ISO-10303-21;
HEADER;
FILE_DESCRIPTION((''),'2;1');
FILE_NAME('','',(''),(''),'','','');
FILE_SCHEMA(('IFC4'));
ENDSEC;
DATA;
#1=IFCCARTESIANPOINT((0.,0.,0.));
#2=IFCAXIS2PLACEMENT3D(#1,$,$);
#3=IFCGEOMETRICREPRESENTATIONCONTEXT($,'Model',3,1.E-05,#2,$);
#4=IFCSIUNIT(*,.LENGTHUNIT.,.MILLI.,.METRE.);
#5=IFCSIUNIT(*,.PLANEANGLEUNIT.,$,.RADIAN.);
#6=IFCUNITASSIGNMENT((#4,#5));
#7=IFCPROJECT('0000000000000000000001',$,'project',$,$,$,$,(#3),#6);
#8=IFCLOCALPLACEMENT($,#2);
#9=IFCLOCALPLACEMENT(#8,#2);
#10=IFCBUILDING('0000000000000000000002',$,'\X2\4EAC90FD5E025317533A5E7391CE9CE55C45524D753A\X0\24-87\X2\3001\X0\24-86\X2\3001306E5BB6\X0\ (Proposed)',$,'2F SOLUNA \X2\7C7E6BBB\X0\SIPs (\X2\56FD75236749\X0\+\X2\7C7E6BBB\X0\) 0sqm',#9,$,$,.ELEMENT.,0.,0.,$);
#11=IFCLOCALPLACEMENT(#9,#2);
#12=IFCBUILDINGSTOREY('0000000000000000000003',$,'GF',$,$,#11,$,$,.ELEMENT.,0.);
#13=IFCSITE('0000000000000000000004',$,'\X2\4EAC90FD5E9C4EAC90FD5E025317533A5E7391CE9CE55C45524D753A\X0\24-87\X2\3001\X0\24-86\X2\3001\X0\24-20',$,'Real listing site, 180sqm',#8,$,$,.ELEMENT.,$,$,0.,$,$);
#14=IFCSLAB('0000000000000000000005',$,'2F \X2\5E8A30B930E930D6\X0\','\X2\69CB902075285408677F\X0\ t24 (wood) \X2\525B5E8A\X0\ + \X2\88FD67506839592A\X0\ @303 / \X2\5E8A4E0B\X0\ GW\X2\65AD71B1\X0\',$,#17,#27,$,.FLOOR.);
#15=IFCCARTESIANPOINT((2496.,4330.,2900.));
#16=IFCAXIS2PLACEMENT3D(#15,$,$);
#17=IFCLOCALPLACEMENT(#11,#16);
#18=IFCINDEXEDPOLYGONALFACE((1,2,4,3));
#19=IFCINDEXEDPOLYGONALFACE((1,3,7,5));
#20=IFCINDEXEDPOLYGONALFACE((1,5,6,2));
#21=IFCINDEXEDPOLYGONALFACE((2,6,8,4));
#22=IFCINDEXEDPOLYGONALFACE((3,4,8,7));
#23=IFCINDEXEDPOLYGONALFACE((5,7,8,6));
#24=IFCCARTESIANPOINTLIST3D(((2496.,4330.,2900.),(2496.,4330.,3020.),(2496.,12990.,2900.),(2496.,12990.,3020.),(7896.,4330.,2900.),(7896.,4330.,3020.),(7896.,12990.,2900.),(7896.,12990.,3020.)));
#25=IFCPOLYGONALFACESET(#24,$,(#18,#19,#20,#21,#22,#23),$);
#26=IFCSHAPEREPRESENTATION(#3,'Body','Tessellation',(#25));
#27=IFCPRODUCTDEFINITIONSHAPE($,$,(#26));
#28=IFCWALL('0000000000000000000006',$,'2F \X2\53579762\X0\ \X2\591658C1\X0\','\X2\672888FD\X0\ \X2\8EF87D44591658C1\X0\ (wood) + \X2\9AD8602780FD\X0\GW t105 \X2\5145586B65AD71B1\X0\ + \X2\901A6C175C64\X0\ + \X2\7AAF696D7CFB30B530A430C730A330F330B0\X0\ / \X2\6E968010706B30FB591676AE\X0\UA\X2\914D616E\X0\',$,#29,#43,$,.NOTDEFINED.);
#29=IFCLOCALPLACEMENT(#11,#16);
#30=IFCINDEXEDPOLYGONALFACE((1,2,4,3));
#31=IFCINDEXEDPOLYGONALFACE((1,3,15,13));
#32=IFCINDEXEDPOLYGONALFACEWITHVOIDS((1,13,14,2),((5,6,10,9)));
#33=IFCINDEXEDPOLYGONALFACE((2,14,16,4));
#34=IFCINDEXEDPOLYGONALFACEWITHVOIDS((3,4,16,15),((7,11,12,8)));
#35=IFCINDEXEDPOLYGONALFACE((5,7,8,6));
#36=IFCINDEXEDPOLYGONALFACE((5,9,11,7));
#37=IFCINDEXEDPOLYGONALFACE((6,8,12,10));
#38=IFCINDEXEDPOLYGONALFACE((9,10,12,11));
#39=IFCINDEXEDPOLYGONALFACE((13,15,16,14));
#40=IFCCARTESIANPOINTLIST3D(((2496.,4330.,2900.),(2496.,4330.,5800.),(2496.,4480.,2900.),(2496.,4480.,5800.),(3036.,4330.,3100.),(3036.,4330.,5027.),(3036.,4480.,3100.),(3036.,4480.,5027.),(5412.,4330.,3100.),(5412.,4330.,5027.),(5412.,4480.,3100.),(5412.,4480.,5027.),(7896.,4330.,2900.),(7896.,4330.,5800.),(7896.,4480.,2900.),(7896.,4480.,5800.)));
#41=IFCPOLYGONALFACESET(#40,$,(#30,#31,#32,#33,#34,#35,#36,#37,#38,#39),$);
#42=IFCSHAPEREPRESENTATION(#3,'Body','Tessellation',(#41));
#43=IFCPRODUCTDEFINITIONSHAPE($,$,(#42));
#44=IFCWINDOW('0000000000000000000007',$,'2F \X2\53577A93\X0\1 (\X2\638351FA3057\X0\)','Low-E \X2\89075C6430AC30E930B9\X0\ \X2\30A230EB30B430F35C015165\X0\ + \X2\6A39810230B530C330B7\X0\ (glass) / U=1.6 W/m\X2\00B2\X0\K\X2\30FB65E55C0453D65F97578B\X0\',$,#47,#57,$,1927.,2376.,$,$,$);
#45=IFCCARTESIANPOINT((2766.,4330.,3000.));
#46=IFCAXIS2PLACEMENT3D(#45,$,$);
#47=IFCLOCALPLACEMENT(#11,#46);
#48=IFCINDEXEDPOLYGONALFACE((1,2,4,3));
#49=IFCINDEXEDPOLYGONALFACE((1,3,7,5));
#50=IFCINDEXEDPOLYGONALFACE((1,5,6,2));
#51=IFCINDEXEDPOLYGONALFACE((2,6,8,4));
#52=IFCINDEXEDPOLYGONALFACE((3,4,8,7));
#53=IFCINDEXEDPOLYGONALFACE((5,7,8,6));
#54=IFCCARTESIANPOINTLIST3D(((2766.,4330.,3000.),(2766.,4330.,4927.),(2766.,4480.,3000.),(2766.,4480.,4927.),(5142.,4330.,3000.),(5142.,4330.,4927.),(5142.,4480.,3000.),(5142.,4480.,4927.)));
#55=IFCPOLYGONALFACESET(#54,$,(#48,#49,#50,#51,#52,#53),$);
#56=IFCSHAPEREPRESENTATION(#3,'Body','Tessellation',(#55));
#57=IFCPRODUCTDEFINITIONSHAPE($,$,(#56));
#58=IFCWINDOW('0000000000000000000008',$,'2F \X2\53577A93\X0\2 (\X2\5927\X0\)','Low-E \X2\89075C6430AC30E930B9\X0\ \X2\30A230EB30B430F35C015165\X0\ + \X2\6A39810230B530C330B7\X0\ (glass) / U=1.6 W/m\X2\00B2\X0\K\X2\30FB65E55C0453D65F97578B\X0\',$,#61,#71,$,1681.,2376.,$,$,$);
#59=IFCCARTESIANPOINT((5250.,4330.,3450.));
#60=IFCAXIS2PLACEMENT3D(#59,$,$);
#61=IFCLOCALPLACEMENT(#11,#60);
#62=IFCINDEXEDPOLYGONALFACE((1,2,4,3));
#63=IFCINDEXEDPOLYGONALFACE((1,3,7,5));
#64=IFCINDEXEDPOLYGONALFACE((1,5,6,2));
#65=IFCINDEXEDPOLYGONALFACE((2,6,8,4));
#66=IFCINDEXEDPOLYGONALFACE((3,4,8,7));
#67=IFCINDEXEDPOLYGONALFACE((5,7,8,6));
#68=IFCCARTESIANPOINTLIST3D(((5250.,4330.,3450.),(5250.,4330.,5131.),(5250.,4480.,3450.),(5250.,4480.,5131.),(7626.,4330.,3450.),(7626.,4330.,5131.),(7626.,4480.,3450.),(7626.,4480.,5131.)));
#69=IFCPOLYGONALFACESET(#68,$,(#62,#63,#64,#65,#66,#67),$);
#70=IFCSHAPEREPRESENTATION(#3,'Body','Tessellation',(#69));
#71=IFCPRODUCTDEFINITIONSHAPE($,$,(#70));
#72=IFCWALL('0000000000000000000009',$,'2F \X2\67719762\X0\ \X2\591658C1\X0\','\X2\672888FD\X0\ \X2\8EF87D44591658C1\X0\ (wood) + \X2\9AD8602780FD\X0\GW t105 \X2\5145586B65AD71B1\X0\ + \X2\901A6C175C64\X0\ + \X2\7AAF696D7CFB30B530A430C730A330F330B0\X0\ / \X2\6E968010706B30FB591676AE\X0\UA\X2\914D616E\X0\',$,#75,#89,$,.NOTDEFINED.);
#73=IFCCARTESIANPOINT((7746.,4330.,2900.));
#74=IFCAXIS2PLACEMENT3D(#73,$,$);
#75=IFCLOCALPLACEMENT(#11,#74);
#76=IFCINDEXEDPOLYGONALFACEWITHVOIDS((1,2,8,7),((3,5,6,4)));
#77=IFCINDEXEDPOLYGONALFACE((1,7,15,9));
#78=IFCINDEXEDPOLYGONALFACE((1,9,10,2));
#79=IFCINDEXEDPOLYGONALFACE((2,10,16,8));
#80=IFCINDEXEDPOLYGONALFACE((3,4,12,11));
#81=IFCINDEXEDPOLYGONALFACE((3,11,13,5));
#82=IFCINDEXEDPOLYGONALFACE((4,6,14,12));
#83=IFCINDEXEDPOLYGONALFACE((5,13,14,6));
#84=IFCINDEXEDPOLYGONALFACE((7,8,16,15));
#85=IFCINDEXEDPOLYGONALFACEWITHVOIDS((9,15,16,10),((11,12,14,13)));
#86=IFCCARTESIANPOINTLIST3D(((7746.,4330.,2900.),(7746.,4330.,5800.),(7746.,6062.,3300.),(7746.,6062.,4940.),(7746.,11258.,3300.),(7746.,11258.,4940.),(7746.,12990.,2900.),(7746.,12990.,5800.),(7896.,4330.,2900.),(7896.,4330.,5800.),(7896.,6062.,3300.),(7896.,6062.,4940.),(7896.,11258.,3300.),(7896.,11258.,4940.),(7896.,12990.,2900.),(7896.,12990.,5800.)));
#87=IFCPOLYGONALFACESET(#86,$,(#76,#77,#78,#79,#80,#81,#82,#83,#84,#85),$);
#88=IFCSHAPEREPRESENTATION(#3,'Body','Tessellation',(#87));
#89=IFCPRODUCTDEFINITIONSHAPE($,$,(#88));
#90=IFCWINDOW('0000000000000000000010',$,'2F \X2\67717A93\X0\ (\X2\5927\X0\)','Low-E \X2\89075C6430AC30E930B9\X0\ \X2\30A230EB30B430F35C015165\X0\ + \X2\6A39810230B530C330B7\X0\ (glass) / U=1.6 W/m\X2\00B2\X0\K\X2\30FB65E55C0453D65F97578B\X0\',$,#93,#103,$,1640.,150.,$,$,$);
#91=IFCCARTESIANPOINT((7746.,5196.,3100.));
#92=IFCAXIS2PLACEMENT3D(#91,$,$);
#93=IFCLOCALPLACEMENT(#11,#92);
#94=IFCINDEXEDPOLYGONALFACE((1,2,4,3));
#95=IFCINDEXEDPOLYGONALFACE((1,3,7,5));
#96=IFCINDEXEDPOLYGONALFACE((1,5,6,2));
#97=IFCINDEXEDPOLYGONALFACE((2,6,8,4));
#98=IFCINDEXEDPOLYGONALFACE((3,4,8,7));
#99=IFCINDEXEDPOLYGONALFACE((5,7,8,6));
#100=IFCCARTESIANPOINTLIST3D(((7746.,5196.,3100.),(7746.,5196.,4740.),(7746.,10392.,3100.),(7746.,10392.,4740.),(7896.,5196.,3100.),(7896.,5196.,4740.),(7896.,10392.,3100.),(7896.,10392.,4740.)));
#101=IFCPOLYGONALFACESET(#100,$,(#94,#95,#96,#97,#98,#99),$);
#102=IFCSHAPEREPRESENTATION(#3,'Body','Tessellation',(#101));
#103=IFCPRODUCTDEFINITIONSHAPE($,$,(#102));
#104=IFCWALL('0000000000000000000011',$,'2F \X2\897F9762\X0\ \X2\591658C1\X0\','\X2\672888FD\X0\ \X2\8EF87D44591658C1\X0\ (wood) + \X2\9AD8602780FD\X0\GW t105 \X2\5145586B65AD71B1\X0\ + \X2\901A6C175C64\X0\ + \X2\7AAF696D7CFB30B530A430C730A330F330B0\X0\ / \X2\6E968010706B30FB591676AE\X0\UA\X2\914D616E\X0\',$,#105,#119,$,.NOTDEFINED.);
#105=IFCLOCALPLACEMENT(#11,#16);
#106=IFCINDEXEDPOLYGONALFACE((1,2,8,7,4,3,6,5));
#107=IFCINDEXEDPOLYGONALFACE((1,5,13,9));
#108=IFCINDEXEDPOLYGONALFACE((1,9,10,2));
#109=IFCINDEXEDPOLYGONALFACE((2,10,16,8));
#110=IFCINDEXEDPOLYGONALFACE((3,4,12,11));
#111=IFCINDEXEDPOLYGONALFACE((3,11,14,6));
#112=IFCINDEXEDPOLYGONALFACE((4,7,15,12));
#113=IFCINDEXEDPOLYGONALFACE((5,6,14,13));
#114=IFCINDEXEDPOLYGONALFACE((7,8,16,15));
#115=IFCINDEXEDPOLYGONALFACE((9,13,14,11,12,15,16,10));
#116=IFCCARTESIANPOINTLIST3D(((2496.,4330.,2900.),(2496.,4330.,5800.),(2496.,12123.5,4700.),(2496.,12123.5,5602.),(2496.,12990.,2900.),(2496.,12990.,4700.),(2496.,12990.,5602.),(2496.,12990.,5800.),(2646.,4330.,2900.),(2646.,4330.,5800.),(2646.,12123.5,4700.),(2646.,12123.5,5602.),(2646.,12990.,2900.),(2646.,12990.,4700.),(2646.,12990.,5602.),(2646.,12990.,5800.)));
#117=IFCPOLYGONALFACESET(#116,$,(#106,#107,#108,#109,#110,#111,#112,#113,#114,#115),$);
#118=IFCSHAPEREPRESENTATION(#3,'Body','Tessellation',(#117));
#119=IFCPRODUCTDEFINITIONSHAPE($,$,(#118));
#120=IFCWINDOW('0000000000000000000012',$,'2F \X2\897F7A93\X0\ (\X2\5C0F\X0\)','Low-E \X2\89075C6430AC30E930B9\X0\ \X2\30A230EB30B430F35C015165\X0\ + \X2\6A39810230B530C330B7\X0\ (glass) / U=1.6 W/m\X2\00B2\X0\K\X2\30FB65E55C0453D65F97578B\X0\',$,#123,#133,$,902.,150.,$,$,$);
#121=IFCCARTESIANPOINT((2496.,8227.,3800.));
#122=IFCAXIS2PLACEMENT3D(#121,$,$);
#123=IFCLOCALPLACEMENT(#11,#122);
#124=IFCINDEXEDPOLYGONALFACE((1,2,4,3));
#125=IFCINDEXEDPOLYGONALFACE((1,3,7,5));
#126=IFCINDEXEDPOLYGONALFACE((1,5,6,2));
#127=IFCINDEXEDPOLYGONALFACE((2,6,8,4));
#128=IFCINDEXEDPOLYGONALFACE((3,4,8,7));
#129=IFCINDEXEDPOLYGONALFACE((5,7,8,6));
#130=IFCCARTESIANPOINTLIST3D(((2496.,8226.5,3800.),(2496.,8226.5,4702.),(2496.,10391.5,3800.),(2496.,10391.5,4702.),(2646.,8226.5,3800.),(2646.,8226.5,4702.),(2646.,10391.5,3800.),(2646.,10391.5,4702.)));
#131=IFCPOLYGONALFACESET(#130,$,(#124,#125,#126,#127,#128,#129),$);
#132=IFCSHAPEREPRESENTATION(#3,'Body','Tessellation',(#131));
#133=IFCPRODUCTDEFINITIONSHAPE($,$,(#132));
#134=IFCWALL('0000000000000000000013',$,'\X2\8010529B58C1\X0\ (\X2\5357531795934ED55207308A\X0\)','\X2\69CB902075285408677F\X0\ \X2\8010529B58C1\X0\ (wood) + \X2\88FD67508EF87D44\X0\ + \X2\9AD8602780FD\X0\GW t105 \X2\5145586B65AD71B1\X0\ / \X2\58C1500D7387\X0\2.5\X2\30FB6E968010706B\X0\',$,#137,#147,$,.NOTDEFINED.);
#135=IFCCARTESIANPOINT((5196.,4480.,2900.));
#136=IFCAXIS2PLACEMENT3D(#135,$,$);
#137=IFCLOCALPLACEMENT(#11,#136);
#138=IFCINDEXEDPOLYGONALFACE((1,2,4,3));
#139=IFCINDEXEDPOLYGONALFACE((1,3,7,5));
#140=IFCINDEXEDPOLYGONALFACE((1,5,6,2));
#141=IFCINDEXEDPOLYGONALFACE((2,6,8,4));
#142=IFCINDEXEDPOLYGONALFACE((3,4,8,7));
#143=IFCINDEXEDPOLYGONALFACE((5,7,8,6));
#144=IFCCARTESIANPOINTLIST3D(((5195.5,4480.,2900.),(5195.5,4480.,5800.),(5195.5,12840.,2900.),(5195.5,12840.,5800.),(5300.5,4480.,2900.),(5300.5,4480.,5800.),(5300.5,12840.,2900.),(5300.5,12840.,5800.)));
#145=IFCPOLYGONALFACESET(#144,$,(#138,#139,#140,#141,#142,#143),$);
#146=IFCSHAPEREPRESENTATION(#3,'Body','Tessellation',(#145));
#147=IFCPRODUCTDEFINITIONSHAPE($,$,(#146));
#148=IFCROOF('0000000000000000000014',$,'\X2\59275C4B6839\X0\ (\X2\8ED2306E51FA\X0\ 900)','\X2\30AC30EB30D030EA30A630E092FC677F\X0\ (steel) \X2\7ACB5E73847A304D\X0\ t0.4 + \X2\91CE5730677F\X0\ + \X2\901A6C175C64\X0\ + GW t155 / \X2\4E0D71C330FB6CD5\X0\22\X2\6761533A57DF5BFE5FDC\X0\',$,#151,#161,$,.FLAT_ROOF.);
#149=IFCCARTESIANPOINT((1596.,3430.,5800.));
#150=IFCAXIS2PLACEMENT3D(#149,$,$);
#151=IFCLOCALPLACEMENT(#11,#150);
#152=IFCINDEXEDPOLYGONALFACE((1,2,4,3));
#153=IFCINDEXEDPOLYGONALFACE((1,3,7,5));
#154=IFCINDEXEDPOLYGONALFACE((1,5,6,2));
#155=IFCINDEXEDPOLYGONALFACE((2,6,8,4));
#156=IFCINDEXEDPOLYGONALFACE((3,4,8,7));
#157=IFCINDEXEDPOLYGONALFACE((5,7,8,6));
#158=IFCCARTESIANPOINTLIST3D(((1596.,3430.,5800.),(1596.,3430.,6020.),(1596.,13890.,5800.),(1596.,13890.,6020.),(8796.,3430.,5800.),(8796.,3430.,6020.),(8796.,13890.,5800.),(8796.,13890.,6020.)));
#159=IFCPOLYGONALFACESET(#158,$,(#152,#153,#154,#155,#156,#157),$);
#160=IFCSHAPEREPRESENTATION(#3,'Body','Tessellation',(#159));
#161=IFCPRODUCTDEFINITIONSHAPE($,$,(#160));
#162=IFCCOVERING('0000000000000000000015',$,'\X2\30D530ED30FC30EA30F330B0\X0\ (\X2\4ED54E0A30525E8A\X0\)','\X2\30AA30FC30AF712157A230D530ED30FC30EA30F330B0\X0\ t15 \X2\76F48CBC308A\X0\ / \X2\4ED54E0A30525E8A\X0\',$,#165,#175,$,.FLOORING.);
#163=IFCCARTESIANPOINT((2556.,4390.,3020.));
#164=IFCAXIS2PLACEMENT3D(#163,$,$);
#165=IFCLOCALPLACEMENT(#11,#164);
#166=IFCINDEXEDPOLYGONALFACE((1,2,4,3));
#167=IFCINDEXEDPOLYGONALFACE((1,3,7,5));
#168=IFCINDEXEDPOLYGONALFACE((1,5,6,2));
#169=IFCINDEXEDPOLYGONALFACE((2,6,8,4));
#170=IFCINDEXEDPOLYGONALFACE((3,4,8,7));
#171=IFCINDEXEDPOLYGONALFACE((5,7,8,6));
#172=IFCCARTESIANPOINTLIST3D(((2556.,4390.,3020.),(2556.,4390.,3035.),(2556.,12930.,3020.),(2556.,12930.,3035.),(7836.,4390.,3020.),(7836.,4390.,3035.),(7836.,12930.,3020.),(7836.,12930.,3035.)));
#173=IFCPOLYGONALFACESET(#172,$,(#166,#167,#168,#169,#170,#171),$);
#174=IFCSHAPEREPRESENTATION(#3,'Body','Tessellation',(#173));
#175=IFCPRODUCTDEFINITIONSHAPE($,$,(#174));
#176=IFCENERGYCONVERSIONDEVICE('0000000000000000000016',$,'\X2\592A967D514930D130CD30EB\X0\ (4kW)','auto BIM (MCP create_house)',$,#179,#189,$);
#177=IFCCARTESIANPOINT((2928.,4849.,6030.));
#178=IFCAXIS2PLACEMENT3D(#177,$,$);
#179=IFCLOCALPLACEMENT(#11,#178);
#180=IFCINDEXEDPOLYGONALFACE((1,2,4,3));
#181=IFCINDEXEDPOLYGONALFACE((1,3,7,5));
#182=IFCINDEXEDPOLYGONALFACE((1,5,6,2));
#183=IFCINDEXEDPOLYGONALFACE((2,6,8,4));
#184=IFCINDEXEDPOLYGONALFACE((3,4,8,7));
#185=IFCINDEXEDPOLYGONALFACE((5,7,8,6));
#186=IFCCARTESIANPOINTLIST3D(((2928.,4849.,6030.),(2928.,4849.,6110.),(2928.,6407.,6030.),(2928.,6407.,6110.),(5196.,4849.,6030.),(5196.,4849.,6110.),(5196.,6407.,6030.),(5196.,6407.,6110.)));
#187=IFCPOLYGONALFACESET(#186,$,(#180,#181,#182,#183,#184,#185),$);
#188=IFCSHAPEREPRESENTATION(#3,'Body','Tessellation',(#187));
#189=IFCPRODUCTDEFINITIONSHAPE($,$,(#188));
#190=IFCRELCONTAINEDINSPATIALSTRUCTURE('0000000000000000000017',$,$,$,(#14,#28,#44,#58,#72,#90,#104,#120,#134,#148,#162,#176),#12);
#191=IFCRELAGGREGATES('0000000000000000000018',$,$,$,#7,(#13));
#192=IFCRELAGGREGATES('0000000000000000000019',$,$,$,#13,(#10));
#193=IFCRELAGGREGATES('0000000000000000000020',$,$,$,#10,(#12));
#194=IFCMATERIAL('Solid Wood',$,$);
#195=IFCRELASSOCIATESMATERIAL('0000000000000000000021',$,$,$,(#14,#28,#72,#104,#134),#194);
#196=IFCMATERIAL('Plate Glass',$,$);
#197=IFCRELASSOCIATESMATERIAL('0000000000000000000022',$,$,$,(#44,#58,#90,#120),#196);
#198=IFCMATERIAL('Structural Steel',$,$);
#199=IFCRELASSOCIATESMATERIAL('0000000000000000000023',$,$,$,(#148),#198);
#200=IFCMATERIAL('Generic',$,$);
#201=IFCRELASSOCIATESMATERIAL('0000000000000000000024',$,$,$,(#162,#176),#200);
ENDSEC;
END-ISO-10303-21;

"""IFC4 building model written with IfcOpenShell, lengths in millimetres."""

from ifc_helpers import new_model, si_unit, frame, frame_2d, origin, place, context, project, spatial, rectangle, extrude, material, element, fill, save


model = new_model("IFC4")

# Units and contexts
model_context = context("Model", 3, precision=1e-05, world=origin())
ifc_project = project(units=[si_unit("LENGTHUNIT", "METRE", prefix="MILLI"), si_unit("PLANEANGLEUNIT", "RADIAN")], contexts=[model_context])

# Site, building, storey
site_placement = place(None, origin())
site = spatial("IfcSite", under=ifc_project, at=site_placement, Name="京都府京都市北区平野鳥居前町24-87、24-86、24-20", ObjectType="Real listing site, 180sqm", CompositionType="ELEMENT", RefElevation=0.0)
building_placement = place(site_placement, origin())
building = spatial("IfcBuilding", under=site, at=building_placement, Name="京都市北区平野鳥居前町24-87、24-86、の家 (Proposed)", ObjectType="2F SOLUNA 籾殻SIPs (国産杉+籾殻) 0sqm", CompositionType="ELEMENT", ElevationOfRefHeight=0.0, ElevationOfTerrain=0.0)
storey_placement = place(building_placement, origin())
storey = spatial("IfcBuildingStorey", under=building, at=storey_placement, Name="GF", CompositionType="ELEMENT", Elevation=0.0)

# Slab
ifc_material_1 = material(Name="Solid Wood")
slab_placement = place(storey_placement, frame((2496.0, 4330.0, 2900.0)))
element("IfcSlab", 1, at=slab_placement, inside=storey, material=ifc_material_1, Name="2F 床スラブ", Description="構造用合板 t24 (wood) 剛床 + 製材根太 @303 / 床下 GW断熱", PredefinedType="FLOOR", context=model_context, shape_type="SweptSolid", body=[
    extrude(rectangle(XDim=5400.0, YDim=8660.0, at=frame_2d((2700.0, 4330.0))), frame((2496.0, 4330.0, 2900.0)), (0.0, 0.0, 1.0), 120.0),
])

# Wall, openings, windows
wall_1_placement = place(storey_placement, frame((2496.0, 4330.0, 2900.0)))
wall_1 = element("IfcWall", 2, at=wall_1_placement, inside=storey, material=ifc_material_1, Name="2F 南面 外壁", Description="木製 軸組外壁 (wood) + 高性能GW t105 充填断熱 + 通気層 + 窯業系サイディング / 準耐火・外皮UA配慮", PredefinedType="NOTDEFINED", context=model_context, shape_type="SweptSolid", body=[
    extrude(rectangle(XDim=5400.0, YDim=150.0, at=frame_2d((2700.0, 75.0))), frame((2496.0, 4330.0, 2900.0)), (0.0, 0.0, 1.0), 2900.0),
])
opening_1_placement = place(storey_placement, frame((2766.0, 4330.0, 3000.0)))
opening_1 = element("IfcOpeningElement", 3, at=opening_1_placement, cuts=wall_1, PredefinedType="NOTDEFINED", context=model_context, shape_type="SweptSolid", body=[
    extrude(rectangle(XDim=2376.0, YDim=150.0, at=frame_2d((1188.0, 75.0))), frame((2766.0, 4330.0, 3000.0)), (0.0, 0.0, 1.0), 1927.0),
])
opening_2_placement = place(storey_placement, frame((5250.0, 4330.0, 3450.0)))
opening_2 = element("IfcOpeningElement", 4, at=opening_2_placement, cuts=wall_1, PredefinedType="NOTDEFINED", context=model_context, shape_type="SweptSolid", body=[
    extrude(rectangle(XDim=2376.0, YDim=150.0, at=frame_2d((1188.0, 75.0))), frame((5250.0, 4330.0, 3450.0)), (0.0, 0.0, 1.0), 1681.0),
])
ifc_material_2 = material(Name="Plate Glass")
window_1_placement = place(storey_placement, frame((2766.0, 4330.0, 3000.0)))
window_1 = element("IfcWindow", 5, at=window_1_placement, inside=storey, material=ifc_material_2, Name="2F 南窓1 (掃出し)", Description="Low-E 複層ガラス アルゴン封入 + 樹脂サッシ (glass) / U=1.6 W/m²K・日射取得型", OverallHeight=1927.0, OverallWidth=2376.0, context=model_context, shape_type="SweptSolid", body=[
    extrude(rectangle(XDim=2376.0, YDim=150.0, at=frame_2d((1188.0, 75.0))), frame((2766.0, 4330.0, 3000.0)), (0.0, 0.0, 1.0), 1927.0),
])
fill(opening_1, window_1)
window_2_placement = place(storey_placement, frame((5250.0, 4330.0, 3450.0)))
window_2 = element("IfcWindow", 6, at=window_2_placement, inside=storey, material=ifc_material_2, Name="2F 南窓2 (大)", Description="Low-E 複層ガラス アルゴン封入 + 樹脂サッシ (glass) / U=1.6 W/m²K・日射取得型", OverallHeight=1681.0, OverallWidth=2376.0, context=model_context, shape_type="SweptSolid", body=[
    extrude(rectangle(XDim=2376.0, YDim=150.0, at=frame_2d((1188.0, 75.0))), frame((5250.0, 4330.0, 3450.0)), (0.0, 0.0, 1.0), 1681.0),
])
fill(opening_2, window_2)

# Walls, openings, windows
wall_2_placement = place(storey_placement, frame((7746.0, 4330.0, 2900.0)))
wall_2 = element("IfcWall", 7, at=wall_2_placement, inside=storey, material=ifc_material_1, Name="2F 東面 外壁", Description="木製 軸組外壁 (wood) + 高性能GW t105 充填断熱 + 通気層 + 窯業系サイディング / 準耐火・外皮UA配慮", PredefinedType="NOTDEFINED", context=model_context, shape_type="SweptSolid", body=[
    extrude(rectangle(XDim=150.0, YDim=8660.0, at=frame_2d((75.0, 4330.0))), frame((7746.0, 4330.0, 2900.0)), (0.0, 0.0, 1.0), 2900.0),
])
opening_3_placement = place(storey_placement, frame((7746.0, 5196.0, 3100.0)))
opening_3 = element("IfcOpeningElement", 8, at=opening_3_placement, cuts=wall_2, PredefinedType="NOTDEFINED", context=model_context, shape_type="SweptSolid", body=[
    extrude(rectangle(XDim=150.0, YDim=5196.0, at=frame_2d((75.0, 2598.0))), frame((7746.0, 5196.0, 3100.0)), (0.0, 0.0, 1.0), 1640.0),
])
window_3_placement = place(storey_placement, frame((7746.0, 5196.0, 3100.0)))
window_3 = element("IfcWindow", 9, at=window_3_placement, inside=storey, material=ifc_material_2, Name="2F 東窓 (大)", Description="Low-E 複層ガラス アルゴン封入 + 樹脂サッシ (glass) / U=1.6 W/m²K・日射取得型", OverallHeight=1640.0, OverallWidth=150.0, context=model_context, shape_type="SweptSolid", body=[
    extrude(rectangle(XDim=150.0, YDim=5196.0, at=frame_2d((75.0, 2598.0))), frame((7746.0, 5196.0, 3100.0)), (0.0, 0.0, 1.0), 1640.0),
])
fill(opening_3, window_3)
wall_3_placement = place(storey_placement, frame((2496.0, 4330.0, 2900.0)))
wall_3 = element("IfcWall", 10, at=wall_3_placement, inside=storey, material=ifc_material_1, Name="2F 西面 外壁", Description="木製 軸組外壁 (wood) + 高性能GW t105 充填断熱 + 通気層 + 窯業系サイディング / 準耐火・外皮UA配慮", PredefinedType="NOTDEFINED", context=model_context, shape_type="SweptSolid", body=[
    extrude(rectangle(XDim=150.0, YDim=8660.0, at=frame_2d((75.0, 4330.0))), frame((2496.0, 4330.0, 2900.0)), (0.0, 0.0, 1.0), 2900.0),
])
opening_4_placement = place(storey_placement, frame((2496.0, 8227.0, 3800.0)))
opening_4 = element("IfcOpeningElement", 11, at=opening_4_placement, cuts=wall_3, PredefinedType="NOTDEFINED", context=model_context, shape_type="SweptSolid", body=[
    extrude(rectangle(XDim=150.0, YDim=2165.0, at=frame_2d((75.0, 1082.0))), frame((2496.0, 8227.0, 3800.0)), (0.0, 0.0, 1.0), 902.0),
])
window_4_placement = place(storey_placement, frame((2496.0, 8227.0, 3800.0)))
window_4 = element("IfcWindow", 12, at=window_4_placement, inside=storey, material=ifc_material_2, Name="2F 西窓 (小)", Description="Low-E 複層ガラス アルゴン封入 + 樹脂サッシ (glass) / U=1.6 W/m²K・日射取得型", OverallHeight=902.0, OverallWidth=150.0, context=model_context, shape_type="SweptSolid", body=[
    extrude(rectangle(XDim=150.0, YDim=2165.0, at=frame_2d((75.0, 1082.0))), frame((2496.0, 8227.0, 3800.0)), (0.0, 0.0, 1.0), 902.0),
])
fill(opening_4, window_4)

# Wall
wall_4_placement = place(storey_placement, frame((5196.0, 4480.0, 2900.0)))
element("IfcWall", 13, at=wall_4_placement, inside=storey, material=ifc_material_1, Name="耐力壁 (南北間仕切り)", Description="構造用合板 耐力壁 (wood) + 製材軸組 + 高性能GW t105 充填断熱 / 壁倍率2.5・準耐火", PredefinedType="NOTDEFINED", context=model_context, shape_type="SweptSolid", body=[
    extrude(rectangle(XDim=105.0, YDim=8360.0, at=frame_2d((52.0, 4180.0))), frame((5196.0, 4480.0, 2900.0)), (0.0, 0.0, 1.0), 2900.0),
])

# Roof
ifc_material_3 = material(Name="Structural Steel")
roof_placement = place(storey_placement, frame((1596.0, 3430.0, 5800.0)))
element("IfcRoof", 14, at=roof_placement, inside=storey, material=ifc_material_3, Name="大屋根 (軒の出 900)", Description="ガルバリウム鋼板 (steel) 立平葺き t0.4 + 野地板 + 通気層 + GW t155 / 不燃・法22条区域対応", PredefinedType="FLAT_ROOF", context=model_context, shape_type="SweptSolid", body=[
    extrude(rectangle(XDim=7200.0, YDim=10460.0, at=frame_2d((3600.0, 5230.0))), frame((1596.0, 3430.0, 5800.0)), (0.0, 0.0, 1.0), 220.0),
])

# Covering
ifc_material_4 = material(Name="Generic")
covering_placement = place(storey_placement, frame((2556.0, 4390.0, 3020.0)))
element("IfcCovering", 15, at=covering_placement, inside=storey, material=ifc_material_4, Name="フローリング (仕上げ床)", Description="オーク無垢フローリング t15 直貼り / 仕上げ床", PredefinedType="FLOORING", context=model_context, shape_type="SweptSolid", body=[
    extrude(rectangle(XDim=5280.0, YDim=8540.0, at=frame_2d((2640.0, 4270.0))), frame((2556.0, 4390.0, 3020.0)), (0.0, 0.0, 1.0), 15.0),
])

# Energy conversion device
energy_conversion_device_placement = place(storey_placement, frame((2928.0, 4849.0, 6030.0)))
element("IfcEnergyConversionDevice", 16, at=energy_conversion_device_placement, inside=storey, material=ifc_material_4, Name="太陽光パネル (4kW)", Description="auto BIM (MCP create_house)", context=model_context, shape_type="SweptSolid", body=[
    extrude(rectangle(XDim=2268.0, YDim=1558.0, at=frame_2d((1134.0, 779.0))), frame((2928.0, 4849.0, 6030.0)), (0.0, 0.0, 1.0), 80.0),
])

save(model, "model.ifc")
